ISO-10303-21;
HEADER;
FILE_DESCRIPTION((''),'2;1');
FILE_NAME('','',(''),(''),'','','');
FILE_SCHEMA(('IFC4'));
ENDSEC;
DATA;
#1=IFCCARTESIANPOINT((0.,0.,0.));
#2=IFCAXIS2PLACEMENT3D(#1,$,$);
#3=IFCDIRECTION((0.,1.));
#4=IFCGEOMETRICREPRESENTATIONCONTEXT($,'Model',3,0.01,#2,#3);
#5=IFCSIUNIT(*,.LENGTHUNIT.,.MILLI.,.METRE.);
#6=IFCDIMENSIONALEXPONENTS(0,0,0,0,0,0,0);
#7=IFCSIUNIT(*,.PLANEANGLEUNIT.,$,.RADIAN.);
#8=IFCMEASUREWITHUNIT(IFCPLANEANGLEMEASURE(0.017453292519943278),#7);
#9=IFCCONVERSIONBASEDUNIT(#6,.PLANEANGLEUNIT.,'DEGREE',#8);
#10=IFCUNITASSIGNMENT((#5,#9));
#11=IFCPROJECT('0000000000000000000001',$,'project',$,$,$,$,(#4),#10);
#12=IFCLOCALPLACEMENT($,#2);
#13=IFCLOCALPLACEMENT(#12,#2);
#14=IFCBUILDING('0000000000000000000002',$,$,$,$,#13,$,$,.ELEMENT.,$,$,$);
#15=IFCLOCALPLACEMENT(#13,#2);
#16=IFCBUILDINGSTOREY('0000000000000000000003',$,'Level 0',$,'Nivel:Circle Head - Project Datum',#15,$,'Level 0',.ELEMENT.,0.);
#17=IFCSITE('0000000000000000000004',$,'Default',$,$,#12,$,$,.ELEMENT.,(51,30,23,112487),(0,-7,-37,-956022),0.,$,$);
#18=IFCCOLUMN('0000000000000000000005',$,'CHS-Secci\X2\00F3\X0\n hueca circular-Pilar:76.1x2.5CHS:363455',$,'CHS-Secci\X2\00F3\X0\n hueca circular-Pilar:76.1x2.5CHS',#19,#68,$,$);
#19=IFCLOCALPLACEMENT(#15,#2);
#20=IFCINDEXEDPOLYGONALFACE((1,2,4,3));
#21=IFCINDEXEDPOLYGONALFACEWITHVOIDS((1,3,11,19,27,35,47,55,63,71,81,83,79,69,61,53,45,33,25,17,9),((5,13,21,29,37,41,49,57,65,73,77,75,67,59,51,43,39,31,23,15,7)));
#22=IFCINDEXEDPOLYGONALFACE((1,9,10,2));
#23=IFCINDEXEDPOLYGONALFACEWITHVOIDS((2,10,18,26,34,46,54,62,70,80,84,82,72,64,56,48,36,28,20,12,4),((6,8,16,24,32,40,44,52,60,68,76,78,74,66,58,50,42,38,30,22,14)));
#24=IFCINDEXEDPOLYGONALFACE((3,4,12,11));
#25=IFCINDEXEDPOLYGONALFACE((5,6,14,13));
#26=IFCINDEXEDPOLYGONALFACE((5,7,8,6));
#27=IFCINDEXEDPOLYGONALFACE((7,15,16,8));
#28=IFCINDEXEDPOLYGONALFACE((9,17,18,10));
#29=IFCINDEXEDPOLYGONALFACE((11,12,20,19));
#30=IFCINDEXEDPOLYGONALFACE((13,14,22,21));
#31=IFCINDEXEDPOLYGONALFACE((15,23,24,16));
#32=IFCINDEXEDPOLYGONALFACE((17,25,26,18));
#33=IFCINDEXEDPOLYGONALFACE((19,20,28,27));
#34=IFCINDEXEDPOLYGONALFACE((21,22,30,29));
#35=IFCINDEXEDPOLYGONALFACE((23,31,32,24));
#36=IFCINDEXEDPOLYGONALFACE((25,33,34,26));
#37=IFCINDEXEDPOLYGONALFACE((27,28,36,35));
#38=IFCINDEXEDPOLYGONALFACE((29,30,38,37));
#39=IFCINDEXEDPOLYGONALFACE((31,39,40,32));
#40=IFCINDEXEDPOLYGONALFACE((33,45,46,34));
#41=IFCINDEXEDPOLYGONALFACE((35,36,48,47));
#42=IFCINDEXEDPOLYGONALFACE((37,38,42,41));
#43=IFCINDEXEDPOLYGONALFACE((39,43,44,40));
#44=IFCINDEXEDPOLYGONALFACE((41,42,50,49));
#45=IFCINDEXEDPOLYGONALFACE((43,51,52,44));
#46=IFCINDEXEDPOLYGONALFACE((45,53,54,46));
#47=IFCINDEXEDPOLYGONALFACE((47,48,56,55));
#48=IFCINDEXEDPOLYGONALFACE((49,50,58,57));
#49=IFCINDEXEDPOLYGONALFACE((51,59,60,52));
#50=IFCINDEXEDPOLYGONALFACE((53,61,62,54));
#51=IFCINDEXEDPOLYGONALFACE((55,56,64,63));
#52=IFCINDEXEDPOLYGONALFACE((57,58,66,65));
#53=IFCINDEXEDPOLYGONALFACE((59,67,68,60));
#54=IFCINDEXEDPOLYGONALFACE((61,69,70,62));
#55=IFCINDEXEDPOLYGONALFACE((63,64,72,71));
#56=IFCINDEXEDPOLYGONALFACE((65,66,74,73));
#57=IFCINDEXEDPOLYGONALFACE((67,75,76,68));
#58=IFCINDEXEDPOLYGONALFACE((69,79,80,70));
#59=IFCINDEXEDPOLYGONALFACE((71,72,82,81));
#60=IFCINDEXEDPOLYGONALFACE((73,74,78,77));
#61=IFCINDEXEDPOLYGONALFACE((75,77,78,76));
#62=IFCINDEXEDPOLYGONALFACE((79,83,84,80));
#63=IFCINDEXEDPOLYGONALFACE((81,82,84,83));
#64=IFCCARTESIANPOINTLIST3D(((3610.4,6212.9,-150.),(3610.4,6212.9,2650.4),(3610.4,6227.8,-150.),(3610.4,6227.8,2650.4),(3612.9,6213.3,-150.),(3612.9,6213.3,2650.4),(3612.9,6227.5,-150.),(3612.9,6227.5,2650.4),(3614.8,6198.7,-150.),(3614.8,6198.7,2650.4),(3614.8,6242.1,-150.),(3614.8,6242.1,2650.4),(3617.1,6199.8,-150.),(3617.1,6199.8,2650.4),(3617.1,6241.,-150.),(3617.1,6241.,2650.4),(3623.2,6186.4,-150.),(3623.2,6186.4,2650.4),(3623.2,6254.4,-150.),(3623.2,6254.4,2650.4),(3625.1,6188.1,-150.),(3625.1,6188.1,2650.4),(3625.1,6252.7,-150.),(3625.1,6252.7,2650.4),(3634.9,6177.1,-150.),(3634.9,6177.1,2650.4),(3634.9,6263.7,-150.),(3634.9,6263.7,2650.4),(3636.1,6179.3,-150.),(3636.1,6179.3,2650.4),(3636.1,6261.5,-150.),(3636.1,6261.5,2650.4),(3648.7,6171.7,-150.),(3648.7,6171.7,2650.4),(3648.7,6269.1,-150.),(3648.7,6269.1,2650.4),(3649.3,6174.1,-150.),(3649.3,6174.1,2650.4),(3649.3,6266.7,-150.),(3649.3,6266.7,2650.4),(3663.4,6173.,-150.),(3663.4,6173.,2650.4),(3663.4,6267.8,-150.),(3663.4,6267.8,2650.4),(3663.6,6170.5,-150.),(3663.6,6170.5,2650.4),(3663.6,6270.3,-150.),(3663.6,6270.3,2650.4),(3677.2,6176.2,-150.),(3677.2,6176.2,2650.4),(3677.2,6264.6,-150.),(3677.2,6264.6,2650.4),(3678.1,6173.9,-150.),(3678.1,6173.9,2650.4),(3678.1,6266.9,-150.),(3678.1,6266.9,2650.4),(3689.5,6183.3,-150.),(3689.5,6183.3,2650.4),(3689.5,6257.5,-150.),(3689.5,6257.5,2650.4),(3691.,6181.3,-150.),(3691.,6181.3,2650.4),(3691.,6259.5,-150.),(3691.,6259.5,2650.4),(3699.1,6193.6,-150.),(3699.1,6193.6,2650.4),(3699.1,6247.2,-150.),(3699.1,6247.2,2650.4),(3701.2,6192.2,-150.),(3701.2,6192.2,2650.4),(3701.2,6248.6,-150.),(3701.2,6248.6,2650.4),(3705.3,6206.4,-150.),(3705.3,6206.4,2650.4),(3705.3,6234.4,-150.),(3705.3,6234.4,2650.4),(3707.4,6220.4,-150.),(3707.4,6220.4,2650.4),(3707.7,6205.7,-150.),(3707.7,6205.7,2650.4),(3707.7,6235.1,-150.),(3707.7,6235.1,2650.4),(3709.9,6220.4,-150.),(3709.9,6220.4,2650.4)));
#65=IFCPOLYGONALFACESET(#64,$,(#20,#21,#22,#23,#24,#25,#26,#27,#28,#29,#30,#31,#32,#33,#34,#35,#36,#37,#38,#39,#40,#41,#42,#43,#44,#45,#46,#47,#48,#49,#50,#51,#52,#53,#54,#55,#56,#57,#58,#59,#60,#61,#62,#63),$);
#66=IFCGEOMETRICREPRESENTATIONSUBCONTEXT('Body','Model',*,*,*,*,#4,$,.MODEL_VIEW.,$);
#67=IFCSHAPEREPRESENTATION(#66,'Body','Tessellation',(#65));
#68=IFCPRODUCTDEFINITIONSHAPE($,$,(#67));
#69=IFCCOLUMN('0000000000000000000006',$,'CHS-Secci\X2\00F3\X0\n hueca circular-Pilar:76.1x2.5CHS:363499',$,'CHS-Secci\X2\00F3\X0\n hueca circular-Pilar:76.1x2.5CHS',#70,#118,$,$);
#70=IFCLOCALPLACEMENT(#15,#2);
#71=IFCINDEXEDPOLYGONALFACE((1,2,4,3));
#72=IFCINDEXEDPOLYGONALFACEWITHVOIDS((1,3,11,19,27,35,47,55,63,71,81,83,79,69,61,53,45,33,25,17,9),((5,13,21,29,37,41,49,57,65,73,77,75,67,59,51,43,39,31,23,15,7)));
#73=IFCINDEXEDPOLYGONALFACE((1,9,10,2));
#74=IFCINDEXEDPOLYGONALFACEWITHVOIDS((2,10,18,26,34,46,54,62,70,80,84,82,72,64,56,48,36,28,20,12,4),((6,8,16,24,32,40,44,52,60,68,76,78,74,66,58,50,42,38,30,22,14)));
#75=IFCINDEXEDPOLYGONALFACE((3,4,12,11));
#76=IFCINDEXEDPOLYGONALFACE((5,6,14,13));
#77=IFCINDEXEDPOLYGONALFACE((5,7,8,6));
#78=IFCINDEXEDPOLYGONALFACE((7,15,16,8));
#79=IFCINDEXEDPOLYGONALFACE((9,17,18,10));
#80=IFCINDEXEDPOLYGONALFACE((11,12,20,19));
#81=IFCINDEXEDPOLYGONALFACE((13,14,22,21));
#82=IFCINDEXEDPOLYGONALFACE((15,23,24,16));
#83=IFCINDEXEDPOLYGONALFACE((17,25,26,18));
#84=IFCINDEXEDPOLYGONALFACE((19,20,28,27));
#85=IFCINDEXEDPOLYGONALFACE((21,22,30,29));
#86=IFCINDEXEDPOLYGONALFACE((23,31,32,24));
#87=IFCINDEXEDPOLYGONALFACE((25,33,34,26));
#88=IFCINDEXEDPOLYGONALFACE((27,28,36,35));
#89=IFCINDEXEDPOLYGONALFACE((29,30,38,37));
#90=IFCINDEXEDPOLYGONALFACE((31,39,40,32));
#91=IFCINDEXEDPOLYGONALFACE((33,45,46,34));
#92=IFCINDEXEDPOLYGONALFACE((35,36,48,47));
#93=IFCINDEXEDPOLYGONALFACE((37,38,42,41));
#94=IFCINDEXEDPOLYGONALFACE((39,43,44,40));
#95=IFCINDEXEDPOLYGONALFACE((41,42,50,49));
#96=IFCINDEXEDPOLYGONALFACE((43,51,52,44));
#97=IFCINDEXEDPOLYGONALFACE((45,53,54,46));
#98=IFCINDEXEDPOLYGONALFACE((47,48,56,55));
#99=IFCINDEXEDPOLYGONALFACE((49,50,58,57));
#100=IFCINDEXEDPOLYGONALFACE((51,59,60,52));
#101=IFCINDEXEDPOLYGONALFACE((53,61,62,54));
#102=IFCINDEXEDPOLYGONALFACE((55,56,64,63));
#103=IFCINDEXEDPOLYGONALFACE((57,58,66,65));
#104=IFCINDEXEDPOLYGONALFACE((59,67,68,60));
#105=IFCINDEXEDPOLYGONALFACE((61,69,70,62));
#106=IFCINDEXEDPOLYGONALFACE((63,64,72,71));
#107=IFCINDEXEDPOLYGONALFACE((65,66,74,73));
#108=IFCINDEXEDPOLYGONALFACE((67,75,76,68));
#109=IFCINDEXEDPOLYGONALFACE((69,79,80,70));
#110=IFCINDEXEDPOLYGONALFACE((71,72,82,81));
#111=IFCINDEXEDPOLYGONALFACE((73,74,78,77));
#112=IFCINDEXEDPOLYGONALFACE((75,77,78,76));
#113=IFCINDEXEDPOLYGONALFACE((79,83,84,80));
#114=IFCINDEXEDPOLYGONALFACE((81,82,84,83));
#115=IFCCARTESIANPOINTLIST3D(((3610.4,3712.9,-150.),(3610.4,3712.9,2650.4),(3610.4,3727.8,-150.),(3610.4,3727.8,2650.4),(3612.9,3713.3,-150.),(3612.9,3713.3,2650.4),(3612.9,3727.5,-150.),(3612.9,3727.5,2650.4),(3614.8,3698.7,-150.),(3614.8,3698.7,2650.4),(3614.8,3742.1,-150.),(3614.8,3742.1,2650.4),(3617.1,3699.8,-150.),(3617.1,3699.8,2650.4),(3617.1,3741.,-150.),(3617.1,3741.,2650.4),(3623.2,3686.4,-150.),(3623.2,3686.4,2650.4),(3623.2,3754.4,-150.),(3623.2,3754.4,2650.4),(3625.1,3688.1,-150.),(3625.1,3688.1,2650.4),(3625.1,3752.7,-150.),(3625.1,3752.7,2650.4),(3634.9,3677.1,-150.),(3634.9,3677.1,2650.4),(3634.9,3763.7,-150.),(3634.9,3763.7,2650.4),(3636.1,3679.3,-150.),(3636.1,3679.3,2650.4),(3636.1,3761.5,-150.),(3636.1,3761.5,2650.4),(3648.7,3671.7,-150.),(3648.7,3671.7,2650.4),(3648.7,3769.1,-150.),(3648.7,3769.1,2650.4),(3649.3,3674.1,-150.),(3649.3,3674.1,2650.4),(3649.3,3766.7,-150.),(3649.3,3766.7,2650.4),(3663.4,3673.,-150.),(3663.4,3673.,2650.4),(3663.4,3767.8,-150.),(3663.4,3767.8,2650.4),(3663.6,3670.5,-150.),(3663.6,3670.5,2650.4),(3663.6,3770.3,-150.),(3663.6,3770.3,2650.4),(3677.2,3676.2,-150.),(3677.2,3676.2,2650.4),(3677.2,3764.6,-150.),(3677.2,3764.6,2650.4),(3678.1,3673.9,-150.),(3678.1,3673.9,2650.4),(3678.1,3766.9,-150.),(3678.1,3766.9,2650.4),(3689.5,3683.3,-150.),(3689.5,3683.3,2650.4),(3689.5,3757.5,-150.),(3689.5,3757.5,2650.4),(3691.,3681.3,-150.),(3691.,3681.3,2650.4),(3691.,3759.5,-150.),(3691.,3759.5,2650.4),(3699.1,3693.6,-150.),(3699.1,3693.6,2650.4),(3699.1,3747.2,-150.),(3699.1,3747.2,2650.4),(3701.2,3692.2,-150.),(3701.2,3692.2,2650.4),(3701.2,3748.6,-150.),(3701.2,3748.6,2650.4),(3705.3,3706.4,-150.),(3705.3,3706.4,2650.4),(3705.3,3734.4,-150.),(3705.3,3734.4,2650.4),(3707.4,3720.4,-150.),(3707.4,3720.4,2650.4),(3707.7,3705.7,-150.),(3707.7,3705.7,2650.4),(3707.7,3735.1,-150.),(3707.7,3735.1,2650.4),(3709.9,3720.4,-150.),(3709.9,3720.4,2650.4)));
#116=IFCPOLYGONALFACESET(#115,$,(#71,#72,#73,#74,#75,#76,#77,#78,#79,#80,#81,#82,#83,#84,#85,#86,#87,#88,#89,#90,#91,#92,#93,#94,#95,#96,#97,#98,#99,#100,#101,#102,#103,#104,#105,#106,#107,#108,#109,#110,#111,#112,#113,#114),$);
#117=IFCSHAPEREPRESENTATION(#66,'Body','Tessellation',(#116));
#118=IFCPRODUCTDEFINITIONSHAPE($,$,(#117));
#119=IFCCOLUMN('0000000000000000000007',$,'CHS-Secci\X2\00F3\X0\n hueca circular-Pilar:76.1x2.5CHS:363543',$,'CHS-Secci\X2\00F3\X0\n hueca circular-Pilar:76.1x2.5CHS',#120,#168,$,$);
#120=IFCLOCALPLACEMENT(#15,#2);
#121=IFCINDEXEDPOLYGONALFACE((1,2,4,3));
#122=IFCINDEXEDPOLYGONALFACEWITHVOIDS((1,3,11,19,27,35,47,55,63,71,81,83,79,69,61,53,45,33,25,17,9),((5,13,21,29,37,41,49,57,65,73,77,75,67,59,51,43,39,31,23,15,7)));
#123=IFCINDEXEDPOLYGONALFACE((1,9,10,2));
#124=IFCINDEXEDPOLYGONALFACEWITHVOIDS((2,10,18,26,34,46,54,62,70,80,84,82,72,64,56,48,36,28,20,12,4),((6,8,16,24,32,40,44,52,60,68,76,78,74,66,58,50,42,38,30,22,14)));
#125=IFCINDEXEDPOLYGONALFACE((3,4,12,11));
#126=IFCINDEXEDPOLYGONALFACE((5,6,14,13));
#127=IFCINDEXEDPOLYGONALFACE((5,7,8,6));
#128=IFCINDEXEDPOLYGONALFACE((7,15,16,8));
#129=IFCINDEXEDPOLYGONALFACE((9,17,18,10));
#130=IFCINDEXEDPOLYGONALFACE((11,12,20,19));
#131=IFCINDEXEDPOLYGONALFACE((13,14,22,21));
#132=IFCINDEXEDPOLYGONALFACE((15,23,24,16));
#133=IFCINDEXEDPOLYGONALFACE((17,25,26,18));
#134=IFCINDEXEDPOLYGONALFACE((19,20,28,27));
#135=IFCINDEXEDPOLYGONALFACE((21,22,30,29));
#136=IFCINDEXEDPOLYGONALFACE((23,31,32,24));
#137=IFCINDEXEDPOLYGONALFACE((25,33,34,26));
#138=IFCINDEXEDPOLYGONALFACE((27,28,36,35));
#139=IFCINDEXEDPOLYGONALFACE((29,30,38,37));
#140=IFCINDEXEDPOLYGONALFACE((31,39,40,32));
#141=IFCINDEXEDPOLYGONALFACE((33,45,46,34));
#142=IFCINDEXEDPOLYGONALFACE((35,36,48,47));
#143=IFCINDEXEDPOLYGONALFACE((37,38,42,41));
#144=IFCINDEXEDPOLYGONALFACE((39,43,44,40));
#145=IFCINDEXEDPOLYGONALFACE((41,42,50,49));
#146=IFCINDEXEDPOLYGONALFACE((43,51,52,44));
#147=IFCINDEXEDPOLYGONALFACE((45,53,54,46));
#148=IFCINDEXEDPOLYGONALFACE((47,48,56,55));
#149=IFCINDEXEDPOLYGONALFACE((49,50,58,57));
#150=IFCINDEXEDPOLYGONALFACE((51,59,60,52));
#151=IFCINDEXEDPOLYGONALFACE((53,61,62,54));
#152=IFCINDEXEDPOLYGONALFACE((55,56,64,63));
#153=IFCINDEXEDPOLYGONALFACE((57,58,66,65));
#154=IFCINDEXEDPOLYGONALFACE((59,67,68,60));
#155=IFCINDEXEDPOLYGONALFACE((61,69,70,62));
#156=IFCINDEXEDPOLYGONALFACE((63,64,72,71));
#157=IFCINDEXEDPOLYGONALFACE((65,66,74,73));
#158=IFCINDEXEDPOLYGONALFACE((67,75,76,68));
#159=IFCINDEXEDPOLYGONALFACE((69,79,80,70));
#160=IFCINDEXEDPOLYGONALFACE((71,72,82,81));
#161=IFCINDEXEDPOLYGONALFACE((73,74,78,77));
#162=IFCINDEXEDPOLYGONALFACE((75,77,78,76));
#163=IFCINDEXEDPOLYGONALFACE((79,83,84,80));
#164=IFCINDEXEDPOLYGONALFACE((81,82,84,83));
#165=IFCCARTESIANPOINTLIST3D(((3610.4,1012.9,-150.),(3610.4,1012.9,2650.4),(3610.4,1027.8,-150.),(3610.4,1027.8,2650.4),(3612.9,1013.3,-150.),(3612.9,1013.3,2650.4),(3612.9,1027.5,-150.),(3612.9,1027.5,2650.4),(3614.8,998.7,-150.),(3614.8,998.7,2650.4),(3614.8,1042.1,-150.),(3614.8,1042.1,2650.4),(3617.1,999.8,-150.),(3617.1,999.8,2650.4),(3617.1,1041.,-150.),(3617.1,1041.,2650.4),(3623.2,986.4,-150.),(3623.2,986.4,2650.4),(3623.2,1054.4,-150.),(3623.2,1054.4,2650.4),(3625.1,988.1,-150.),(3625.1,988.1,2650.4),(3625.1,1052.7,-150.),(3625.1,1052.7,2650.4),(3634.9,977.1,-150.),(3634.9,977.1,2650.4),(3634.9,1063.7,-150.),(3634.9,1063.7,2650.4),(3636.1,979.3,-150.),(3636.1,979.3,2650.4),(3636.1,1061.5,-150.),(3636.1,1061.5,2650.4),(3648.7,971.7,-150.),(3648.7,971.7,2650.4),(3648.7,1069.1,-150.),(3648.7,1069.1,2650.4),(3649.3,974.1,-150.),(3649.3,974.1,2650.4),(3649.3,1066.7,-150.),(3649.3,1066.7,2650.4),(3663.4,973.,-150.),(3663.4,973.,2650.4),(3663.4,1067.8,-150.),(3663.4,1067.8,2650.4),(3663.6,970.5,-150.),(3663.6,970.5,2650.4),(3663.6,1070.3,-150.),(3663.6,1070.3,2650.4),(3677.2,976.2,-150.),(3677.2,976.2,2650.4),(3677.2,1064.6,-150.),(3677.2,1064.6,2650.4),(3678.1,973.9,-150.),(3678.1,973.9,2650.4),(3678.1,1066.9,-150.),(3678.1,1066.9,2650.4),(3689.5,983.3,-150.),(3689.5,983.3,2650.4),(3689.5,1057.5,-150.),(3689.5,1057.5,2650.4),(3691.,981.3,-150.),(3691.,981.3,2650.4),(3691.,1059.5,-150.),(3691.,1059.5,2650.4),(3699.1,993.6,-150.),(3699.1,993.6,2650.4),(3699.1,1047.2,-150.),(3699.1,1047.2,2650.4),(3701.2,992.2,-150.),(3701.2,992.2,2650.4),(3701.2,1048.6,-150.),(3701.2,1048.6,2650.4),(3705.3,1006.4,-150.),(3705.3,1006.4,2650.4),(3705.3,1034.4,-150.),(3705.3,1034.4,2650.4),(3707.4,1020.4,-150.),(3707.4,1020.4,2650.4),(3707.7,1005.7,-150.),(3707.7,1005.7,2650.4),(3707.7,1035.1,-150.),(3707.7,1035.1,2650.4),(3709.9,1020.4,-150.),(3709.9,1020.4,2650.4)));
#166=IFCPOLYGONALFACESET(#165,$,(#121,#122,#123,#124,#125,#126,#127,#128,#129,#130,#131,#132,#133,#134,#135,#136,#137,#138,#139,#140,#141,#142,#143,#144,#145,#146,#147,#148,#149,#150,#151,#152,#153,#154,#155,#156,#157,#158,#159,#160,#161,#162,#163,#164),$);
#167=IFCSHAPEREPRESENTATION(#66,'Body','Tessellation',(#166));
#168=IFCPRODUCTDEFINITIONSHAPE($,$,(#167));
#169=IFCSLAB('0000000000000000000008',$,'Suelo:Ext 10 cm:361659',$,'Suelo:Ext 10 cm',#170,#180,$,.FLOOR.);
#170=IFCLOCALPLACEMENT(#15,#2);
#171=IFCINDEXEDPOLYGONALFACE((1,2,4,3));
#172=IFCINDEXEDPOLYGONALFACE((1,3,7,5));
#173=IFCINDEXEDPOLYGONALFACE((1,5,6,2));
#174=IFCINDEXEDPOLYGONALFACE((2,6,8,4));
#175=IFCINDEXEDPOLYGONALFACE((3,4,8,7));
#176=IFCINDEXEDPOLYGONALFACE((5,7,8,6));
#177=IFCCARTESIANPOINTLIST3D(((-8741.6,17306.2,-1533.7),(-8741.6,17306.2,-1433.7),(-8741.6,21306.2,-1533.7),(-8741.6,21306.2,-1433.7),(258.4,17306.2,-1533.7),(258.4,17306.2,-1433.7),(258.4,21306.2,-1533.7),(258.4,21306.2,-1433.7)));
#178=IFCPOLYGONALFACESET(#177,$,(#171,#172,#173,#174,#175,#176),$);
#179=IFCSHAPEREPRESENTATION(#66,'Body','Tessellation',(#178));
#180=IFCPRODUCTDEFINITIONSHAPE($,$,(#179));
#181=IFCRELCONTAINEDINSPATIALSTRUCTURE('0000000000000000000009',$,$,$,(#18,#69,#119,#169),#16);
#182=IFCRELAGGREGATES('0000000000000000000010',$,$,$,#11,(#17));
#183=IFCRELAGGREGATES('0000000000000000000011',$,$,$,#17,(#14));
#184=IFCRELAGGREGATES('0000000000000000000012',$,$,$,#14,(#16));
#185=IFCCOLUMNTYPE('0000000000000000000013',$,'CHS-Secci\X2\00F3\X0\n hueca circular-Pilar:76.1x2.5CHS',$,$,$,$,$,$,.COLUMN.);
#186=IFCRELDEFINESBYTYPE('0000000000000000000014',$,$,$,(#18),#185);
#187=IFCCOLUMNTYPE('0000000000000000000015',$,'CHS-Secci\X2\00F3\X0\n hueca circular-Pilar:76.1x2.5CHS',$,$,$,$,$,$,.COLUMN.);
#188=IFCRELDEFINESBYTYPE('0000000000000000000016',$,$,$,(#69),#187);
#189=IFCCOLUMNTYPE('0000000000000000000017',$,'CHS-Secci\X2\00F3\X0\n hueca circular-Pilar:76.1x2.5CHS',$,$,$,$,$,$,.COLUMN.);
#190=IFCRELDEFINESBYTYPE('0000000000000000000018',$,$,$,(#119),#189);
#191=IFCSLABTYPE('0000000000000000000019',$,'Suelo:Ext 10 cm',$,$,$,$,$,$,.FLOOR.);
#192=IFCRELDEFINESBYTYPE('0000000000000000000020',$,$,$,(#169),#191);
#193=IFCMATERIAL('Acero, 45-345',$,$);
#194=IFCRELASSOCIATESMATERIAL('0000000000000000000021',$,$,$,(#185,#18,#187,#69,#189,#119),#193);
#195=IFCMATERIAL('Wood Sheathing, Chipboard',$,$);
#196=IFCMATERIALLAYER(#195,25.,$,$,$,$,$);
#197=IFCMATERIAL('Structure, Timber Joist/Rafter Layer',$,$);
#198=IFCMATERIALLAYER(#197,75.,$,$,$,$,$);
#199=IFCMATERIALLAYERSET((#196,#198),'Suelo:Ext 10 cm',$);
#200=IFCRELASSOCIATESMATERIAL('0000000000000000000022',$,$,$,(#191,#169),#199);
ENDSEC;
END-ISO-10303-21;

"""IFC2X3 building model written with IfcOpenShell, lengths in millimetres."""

from ifc_helpers import new_model, entity, si_unit, converted_unit, direction, frame, frame_2d, origin, origin_2d_with_axis, place, context, subcontext, project, spatial, rectangle, hollow_circle, extrude, source, transform, mapped, material, layer, layer_set, layer_usage, type_object, type_shapes, element, save


model = new_model("IFC2X3")

# Units and contexts
model_context = context("Model", 3, precision=0.01, world=origin(), true_north=direction((0.0, 1.0)))
body_context = subcontext(model_context, "Body", "Model", "MODEL_VIEW")
ifc_project = project(units=[si_unit("LENGTHUNIT", "METRE", prefix="MILLI"), converted_unit("PLANEANGLEUNIT", "DEGREE", entity("IfcPlaneAngleMeasure", 0.017453292519943278), si_unit("PLANEANGLEUNIT", "RADIAN"), dimensions=[0, 0, 0, 0, 0, 0, 0])], contexts=[model_context])

# Site, building, storey
site_placement = place(None, origin())
site = spatial("IfcSite", under=ifc_project, at=site_placement, Name="Default", CompositionType="ELEMENT", RefLatitude=(51, 30, 23, 112487), RefLongitude=(0, -7, -37, -956022), RefElevation=0.0)
building_placement = place(site_placement, origin())
building = spatial("IfcBuilding", under=site, at=building_placement, CompositionType="ELEMENT")
storey_placement = place(building_placement, origin())
storey = spatial("IfcBuildingStorey", under=building, at=storey_placement, Name="Level 0", ObjectType="Nivel:Circle Head - Project Datum", LongName="Level 0", CompositionType="ELEMENT", Elevation=0.0)

# Columns
ifc_material_1 = material(Name="Acero, 45-345")
column_type_1 = type_object("IfcColumnType", Name="CHS-Sección hueca circular-Pilar:76.1x2.5CHS", PredefinedType="COLUMN", material=ifc_material_1)
shared_shape_1 = source(origin(), body_context, "Body", "SweptSolid", [
    extrude(hollow_circle(Radius=50.0, WallThickness=2.5, at=origin_2d_with_axis()), frame((3659.9, 6220.4, -150.0)), (0.0, 0.0, 1.0), 2800.4),
])
type_shapes(column_type_1, [shared_shape_1])
column_1_placement = place(storey_placement, origin())
element("IfcColumn", 1, at=column_1_placement, inside=storey, type_object=column_type_1, material=ifc_material_1, Name="CHS-Sección hueca circular-Pilar:76.1x2.5CHS:363455", ObjectType="CHS-Sección hueca circular-Pilar:76.1x2.5CHS", context=body_context, shape_type="MappedRepresentation", body=[
    mapped(shared_shape_1, transform((0.0, 0.0, 0.0), scale=1.0)),
])
column_type_2 = type_object("IfcColumnType", Name="CHS-Sección hueca circular-Pilar:76.1x2.5CHS", PredefinedType="COLUMN", material=ifc_material_1)
shared_shape_2 = source(origin(), body_context, "Body", "SweptSolid", [
    extrude(hollow_circle(Radius=50.0, WallThickness=2.5, at=frame_2d((0.0, 0.0), x_axis=(1.0, 0.0))), frame((3659.9, 3720.4, -150.0)), (0.0, 0.0, 1.0), 2800.4),
])
type_shapes(column_type_2, [shared_shape_2])
column_2_placement = place(storey_placement, origin())
element("IfcColumn", 2, at=column_2_placement, inside=storey, type_object=column_type_2, material=ifc_material_1, Name="CHS-Sección hueca circular-Pilar:76.1x2.5CHS:363499", ObjectType="CHS-Sección hueca circular-Pilar:76.1x2.5CHS", context=body_context, shape_type="MappedRepresentation", body=[
    mapped(shared_shape_2, transform((0.0, 0.0, 0.0), scale=1.0)),
])
column_type_3 = type_object("IfcColumnType", Name="CHS-Sección hueca circular-Pilar:76.1x2.5CHS", PredefinedType="COLUMN", material=ifc_material_1)
shared_shape_3 = source(origin(), body_context, "Body", "SweptSolid", [
    extrude(hollow_circle(Radius=50.0, WallThickness=2.5, at=frame_2d((0.0, 0.0), x_axis=(1.0, 0.0))), frame((3659.9, 1020.4, -150.0)), (0.0, 0.0, 1.0), 2800.4),
])
type_shapes(column_type_3, [shared_shape_3])
column_3_placement = place(storey_placement, origin())
element("IfcColumn", 3, at=column_3_placement, inside=storey, type_object=column_type_3, material=ifc_material_1, Name="CHS-Sección hueca circular-Pilar:76.1x2.5CHS:363543", ObjectType="CHS-Sección hueca circular-Pilar:76.1x2.5CHS", context=body_context, shape_type="MappedRepresentation", body=[
    mapped(shared_shape_3, transform((0.0, 0.0, 0.0), scale=1.0)),
])

# Slab
ifc_material_2 = material(Name="Wood Sheathing, Chipboard")
ifc_layer_1 = layer(ifc_material_2, 25.0)
ifc_material_3 = material(Name="Structure, Timber Joist/Rafter Layer")
ifc_layer_2 = layer(ifc_material_3, 75.0)
ifc_layer_set_1 = layer_set([ifc_layer_1, ifc_layer_2], Name="Suelo:Ext 10 cm")
ifc_layer_usage_1 = layer_usage(ifc_layer_set_1, "AXIS3", "POSITIVE", 0.0)
slab_type_1 = type_object("IfcSlabType", Name="Suelo:Ext 10 cm", PredefinedType="FLOOR", material=ifc_layer_set_1)
slab_1_placement = place(storey_placement, origin())
element("IfcSlab", 4, at=slab_1_placement, inside=storey, type_object=slab_type_1, material=ifc_layer_usage_1, Name="Suelo:Ext 10 cm:361659", ObjectType="Suelo:Ext 10 cm", PredefinedType="FLOOR", context=body_context, shape_type="SweptSolid", body=[
    extrude(rectangle(XDim=4000.0, YDim=9000.0, at=origin_2d_with_axis()), frame((-4241.6, 19306.2, -1433.7), z_axis=(0.0, 0.0, -1.0), x_axis=(0.0, 1.0, 0.0)), (0.0, 0.0, 1.0), 100.0),
])

save(model, "model.ifc")
